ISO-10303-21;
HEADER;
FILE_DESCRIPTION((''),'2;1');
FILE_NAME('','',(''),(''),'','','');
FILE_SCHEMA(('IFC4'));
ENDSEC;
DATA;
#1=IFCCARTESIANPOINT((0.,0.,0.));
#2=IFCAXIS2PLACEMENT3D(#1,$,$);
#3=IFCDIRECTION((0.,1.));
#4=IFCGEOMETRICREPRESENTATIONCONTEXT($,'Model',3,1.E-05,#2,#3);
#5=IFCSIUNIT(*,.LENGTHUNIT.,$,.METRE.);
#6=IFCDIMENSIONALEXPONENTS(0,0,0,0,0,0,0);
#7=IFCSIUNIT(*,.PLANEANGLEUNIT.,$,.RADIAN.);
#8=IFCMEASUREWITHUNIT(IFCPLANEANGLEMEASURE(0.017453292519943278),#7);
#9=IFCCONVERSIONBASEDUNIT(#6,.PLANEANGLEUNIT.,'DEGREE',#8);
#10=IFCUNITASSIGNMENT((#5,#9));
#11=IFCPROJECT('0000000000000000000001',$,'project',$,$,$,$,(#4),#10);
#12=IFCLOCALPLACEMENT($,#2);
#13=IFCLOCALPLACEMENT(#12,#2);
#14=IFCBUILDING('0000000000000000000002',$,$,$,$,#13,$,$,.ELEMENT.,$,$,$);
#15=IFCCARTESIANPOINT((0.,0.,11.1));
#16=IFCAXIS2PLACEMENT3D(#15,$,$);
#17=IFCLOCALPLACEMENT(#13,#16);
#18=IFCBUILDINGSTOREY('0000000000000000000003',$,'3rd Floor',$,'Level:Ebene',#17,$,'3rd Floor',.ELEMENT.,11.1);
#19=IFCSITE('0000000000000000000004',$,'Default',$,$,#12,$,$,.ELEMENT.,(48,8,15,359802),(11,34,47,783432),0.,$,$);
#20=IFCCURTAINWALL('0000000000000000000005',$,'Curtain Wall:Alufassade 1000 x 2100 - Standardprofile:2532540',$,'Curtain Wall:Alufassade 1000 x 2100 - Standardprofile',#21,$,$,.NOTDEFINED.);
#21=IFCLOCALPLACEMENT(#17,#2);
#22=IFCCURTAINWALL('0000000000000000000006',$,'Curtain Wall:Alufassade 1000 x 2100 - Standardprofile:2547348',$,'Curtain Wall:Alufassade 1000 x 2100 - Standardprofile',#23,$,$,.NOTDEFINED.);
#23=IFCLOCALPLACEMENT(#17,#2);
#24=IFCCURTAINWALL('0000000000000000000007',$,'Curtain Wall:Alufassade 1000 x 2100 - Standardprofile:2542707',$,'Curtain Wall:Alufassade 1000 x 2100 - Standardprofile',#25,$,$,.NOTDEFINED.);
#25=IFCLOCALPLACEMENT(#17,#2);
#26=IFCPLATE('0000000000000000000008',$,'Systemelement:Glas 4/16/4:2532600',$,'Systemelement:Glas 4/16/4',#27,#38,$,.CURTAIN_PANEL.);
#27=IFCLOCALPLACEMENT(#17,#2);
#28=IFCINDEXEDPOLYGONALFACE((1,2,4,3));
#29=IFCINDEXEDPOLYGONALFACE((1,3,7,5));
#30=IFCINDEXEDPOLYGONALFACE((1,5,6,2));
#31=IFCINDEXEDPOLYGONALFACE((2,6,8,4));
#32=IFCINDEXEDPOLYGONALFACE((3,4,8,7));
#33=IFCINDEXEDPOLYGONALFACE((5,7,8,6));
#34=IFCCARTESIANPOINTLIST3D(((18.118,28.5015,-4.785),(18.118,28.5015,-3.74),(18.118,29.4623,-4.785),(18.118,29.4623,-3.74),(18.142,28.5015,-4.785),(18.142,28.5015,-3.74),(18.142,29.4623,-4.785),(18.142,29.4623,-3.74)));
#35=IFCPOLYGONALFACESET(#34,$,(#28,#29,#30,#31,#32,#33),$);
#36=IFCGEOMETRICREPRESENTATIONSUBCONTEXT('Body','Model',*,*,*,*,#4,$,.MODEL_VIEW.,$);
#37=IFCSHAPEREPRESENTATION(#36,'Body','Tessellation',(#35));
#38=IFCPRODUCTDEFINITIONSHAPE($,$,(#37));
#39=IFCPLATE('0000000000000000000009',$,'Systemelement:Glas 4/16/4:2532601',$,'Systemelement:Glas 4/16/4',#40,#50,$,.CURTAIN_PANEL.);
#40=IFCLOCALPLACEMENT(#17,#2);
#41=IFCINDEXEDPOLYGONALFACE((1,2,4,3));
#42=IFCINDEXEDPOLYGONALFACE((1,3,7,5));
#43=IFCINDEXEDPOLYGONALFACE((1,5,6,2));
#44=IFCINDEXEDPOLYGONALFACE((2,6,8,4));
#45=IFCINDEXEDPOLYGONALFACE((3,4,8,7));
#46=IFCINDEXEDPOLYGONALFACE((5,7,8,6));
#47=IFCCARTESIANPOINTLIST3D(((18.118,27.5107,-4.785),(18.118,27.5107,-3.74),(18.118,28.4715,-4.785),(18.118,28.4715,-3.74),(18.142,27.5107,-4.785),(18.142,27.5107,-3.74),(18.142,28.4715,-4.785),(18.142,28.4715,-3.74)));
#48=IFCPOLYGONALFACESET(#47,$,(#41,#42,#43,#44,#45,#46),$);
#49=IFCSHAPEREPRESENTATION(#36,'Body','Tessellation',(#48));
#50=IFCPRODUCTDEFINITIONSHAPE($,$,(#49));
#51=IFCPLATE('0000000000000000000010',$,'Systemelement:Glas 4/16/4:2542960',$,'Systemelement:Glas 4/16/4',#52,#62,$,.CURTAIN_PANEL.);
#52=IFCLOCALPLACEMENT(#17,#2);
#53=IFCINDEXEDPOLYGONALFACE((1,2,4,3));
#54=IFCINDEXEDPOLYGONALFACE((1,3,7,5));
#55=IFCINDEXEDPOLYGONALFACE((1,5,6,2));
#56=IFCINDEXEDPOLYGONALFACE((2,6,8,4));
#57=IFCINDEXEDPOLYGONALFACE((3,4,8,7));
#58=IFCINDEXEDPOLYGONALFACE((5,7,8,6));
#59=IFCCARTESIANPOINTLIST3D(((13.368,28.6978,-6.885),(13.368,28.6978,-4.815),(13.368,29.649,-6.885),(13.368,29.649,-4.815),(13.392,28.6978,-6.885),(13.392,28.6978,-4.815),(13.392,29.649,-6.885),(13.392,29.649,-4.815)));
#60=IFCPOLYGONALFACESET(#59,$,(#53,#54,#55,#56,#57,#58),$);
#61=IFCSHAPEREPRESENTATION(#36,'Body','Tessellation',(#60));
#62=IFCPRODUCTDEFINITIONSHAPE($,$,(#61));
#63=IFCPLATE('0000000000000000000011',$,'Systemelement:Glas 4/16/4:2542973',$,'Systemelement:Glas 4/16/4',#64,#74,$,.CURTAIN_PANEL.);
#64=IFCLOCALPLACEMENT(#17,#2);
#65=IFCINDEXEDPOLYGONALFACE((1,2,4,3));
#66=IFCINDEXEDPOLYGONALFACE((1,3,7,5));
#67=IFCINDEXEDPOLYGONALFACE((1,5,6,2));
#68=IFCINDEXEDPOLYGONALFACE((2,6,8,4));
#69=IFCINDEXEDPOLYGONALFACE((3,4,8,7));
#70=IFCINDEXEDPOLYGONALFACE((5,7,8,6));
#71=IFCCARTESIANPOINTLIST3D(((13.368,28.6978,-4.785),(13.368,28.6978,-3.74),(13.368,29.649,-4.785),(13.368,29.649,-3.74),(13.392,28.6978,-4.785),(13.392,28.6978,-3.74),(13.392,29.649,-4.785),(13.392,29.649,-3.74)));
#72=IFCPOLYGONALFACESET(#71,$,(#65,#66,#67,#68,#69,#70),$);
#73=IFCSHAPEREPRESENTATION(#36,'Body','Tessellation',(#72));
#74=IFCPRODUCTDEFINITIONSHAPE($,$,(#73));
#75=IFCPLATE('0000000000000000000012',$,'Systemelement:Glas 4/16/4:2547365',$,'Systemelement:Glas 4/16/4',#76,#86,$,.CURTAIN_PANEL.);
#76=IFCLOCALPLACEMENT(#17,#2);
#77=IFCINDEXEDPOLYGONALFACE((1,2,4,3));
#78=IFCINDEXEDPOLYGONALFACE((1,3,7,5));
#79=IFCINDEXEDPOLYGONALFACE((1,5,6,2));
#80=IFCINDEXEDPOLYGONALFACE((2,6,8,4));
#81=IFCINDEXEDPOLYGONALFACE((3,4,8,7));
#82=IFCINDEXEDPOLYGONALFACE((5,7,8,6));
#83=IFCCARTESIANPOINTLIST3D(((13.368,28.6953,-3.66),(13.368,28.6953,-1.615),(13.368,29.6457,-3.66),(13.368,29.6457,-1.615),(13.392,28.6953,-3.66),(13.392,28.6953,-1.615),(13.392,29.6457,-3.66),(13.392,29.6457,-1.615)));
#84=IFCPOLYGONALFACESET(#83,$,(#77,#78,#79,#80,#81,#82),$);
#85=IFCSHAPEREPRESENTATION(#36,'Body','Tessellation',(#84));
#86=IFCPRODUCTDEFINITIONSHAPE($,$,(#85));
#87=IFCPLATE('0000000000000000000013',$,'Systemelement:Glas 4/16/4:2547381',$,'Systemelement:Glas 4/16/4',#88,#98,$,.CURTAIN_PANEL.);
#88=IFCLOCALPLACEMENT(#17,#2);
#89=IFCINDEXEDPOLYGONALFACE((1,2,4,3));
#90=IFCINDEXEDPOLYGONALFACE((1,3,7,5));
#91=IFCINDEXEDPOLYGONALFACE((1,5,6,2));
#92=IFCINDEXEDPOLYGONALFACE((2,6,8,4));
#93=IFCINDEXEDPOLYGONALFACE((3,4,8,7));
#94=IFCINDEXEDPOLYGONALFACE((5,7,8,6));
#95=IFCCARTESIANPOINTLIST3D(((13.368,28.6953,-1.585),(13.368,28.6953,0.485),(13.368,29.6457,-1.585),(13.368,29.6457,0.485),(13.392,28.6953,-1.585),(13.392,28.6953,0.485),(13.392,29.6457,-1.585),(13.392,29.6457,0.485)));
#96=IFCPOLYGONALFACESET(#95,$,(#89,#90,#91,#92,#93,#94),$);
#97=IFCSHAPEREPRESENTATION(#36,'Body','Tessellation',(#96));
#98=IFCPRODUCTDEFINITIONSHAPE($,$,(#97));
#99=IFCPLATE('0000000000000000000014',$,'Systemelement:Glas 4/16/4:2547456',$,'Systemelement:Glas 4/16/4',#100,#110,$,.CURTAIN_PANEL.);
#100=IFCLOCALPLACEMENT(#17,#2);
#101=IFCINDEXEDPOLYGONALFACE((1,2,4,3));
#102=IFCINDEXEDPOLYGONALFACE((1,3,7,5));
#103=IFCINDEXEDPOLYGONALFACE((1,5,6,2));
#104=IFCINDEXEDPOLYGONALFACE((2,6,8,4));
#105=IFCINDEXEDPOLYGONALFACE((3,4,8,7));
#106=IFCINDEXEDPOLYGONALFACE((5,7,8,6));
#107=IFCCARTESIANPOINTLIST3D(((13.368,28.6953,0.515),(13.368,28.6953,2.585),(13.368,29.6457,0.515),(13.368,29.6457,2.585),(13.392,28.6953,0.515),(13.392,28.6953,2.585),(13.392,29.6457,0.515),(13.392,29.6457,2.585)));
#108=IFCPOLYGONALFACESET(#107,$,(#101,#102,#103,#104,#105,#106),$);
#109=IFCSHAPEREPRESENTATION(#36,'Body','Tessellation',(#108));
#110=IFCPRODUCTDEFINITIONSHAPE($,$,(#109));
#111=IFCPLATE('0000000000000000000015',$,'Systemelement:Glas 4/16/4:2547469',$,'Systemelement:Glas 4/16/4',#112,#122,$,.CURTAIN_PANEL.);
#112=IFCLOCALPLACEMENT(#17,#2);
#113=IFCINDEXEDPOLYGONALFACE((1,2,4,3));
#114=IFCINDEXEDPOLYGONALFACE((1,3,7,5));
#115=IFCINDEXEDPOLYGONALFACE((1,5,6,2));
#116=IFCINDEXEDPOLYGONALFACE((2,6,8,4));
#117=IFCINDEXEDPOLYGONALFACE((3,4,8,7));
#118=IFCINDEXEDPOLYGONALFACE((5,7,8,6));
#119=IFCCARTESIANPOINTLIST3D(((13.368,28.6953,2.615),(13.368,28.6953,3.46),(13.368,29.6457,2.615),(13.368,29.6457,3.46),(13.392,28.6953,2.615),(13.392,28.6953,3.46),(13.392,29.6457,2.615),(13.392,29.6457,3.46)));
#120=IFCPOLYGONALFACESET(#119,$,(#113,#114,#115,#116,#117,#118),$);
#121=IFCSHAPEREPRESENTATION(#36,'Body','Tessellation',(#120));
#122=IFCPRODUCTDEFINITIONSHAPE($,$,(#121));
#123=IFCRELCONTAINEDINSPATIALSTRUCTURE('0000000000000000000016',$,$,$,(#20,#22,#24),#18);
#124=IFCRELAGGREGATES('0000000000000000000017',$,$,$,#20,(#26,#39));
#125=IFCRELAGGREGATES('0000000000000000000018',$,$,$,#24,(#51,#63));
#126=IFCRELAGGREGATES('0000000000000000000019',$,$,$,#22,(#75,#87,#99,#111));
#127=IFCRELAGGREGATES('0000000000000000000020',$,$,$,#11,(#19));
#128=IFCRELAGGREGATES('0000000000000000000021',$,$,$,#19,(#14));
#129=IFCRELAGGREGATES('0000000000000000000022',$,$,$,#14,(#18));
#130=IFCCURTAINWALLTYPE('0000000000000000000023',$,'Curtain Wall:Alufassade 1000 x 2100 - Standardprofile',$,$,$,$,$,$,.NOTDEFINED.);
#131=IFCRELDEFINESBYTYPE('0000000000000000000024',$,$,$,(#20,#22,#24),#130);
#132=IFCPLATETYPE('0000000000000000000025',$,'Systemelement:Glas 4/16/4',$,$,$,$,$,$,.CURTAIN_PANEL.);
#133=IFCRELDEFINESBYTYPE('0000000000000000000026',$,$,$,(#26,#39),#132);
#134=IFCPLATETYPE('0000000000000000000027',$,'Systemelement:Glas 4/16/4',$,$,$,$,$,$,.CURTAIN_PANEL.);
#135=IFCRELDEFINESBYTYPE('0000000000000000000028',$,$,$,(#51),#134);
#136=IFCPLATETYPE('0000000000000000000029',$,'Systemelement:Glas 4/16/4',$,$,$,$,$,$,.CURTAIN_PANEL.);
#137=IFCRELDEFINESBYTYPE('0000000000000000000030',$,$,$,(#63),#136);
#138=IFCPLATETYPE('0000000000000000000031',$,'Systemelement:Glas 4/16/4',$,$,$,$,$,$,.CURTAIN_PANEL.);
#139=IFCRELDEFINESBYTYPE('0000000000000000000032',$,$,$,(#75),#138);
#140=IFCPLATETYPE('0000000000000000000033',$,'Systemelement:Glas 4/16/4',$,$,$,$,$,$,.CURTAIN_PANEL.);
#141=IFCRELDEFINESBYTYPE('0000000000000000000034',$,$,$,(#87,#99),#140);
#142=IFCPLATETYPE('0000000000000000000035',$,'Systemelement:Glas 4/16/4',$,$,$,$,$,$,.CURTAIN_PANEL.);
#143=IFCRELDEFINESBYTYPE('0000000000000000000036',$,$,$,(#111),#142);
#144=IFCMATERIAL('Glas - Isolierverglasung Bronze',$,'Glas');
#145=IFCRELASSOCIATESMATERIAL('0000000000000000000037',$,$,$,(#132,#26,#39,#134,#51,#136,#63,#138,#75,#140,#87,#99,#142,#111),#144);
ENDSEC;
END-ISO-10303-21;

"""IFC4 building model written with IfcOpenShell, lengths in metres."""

from ifc_helpers import new_model, entity, si_unit, converted_unit, direction, frame, origin, place, context, subcontext, project, spatial, indexed_curve, outline, extrude, source, transform, mapped, material, type_object, type_shapes, element, aggregate, save


model = new_model("IFC4")

# Units and contexts
model_context = context("Model", 3, precision=1e-05, world=origin(), true_north=direction((0.0, 1.0)))
body_context = subcontext(model_context, "Body", "Model", "MODEL_VIEW")
ifc_project = project(units=[si_unit("LENGTHUNIT", "METRE"), converted_unit("PLANEANGLEUNIT", "DEGREE", entity("IfcPlaneAngleMeasure", 0.017453292519943278), si_unit("PLANEANGLEUNIT", "RADIAN"), dimensions=[0, 0, 0, 0, 0, 0, 0])], contexts=[model_context])

# Site, building, storey
site_placement = place(None, origin())
site = spatial("IfcSite", under=ifc_project, at=site_placement, Name="Default", CompositionType="ELEMENT", RefLatitude=(48, 8, 15, 359802), RefLongitude=(11, 34, 47, 783432), RefElevation=0.0)
building_placement = place(site_placement, origin())
building = spatial("IfcBuilding", under=site, at=building_placement, CompositionType="ELEMENT")
storey_placement = place(building_placement, frame((0.0, 0.0, 11.1)))
storey = spatial("IfcBuildingStorey", under=building, at=storey_placement, Name="3rd Floor", ObjectType="Level:Ebene", LongName="3rd Floor", CompositionType="ELEMENT", Elevation=11.1)

# Curtain walls
curtain_wall_type = type_object("IfcCurtainWallType", Name="Curtain Wall:Alufassade 1000 x 2100 - Standardprofile", PredefinedType="NOTDEFINED")
curtain_wall_1_placement = place(storey_placement, frame((0.0, 0.0, -11.1)))
curtain_wall_1 = element("IfcCurtainWall", 1, at=curtain_wall_1_placement, inside=storey, type_object=curtain_wall_type, Name="Curtain Wall:Alufassade 1000 x 2100 - Standardprofile:2532540", ObjectType="Curtain Wall:Alufassade 1000 x 2100 - Standardprofile", PredefinedType="NOTDEFINED")
curtain_wall_2_placement = place(storey_placement, frame((0.0, 0.0, -11.1)))
curtain_wall_2 = element("IfcCurtainWall", 2, at=curtain_wall_2_placement, inside=storey, type_object=curtain_wall_type, Name="Curtain Wall:Alufassade 1000 x 2100 - Standardprofile:2547348", ObjectType="Curtain Wall:Alufassade 1000 x 2100 - Standardprofile", PredefinedType="NOTDEFINED")

# Curtain wall
curtain_wall_3_placement = place(storey_placement, frame((0.0, 0.0, -11.1)))
curtain_wall_3 = element("IfcCurtainWall", 3, at=curtain_wall_3_placement, inside=storey, type_object=curtain_wall_type, Name="Curtain Wall:Alufassade 1000 x 2100 - Standardprofile:2542707", ObjectType="Curtain Wall:Alufassade 1000 x 2100 - Standardprofile", PredefinedType="NOTDEFINED")

# Plates
ifc_material_1 = material(Name="Glas - Isolierverglasung Bronze", Category="Glas")
plate_type_1 = type_object("IfcPlateType", Name="Systemelement:Glas 4/16/4", PredefinedType="CURTAIN_PANEL", material=ifc_material_1)
shared_shape_1 = source(origin(), body_context, "Body", "SweptSolid", [
    extrude(outline(indexed_curve([(-0.012, -0.4804), (0.012, -0.4804), (0.012, 0.4804), (-0.012, 0.4804), (-0.012, -0.4804)], self_intersect=False)), frame((0.0, 0.0, 0.0), z_axis=(0.0, 0.0, 1.0), x_axis=(0.0, 1.0, 0.0)), (0.0, 0.0, 1.0), 1.045),
])
type_shapes(plate_type_1, [shared_shape_1])
plate_1_placement = place(curtain_wall_1_placement, frame((18.13, 28.9819, 6.315), z_axis=(0.0, 0.0, 1.0), x_axis=(0.0, -1.0, 0.0)))
plate_1 = element("IfcPlate", 4, at=plate_1_placement, type_object=plate_type_1, material=ifc_material_1, Name="Systemelement:Glas 4/16/4:2532600", ObjectType="Systemelement:Glas 4/16/4", PredefinedType="CURTAIN_PANEL", context=body_context, shape_type="MappedRepresentation", body=[
    mapped(shared_shape_1, transform((0.0, 0.0, 0.0), scale=1.0)),
])
plate_2_placement = place(curtain_wall_1_placement, frame((18.13, 27.9911, 6.315), z_axis=(0.0, 0.0, 1.0), x_axis=(0.0, -1.0, 0.0)))
plate_2 = element("IfcPlate", 5, at=plate_2_placement, type_object=plate_type_1, material=ifc_material_1, Name="Systemelement:Glas 4/16/4:2532601", ObjectType="Systemelement:Glas 4/16/4", PredefinedType="CURTAIN_PANEL", context=body_context, shape_type="MappedRepresentation", body=[
    mapped(shared_shape_1, transform((0.0, 0.0, 0.0), scale=1.0)),
])
aggregate(curtain_wall_1, [plate_1, plate_2])
plate_type_2 = type_object("IfcPlateType", Name="Systemelement:Glas 4/16/4", PredefinedType="CURTAIN_PANEL", material=ifc_material_1)
shared_shape_2 = source(origin(), body_context, "Body", "SweptSolid", [
    extrude(outline(indexed_curve([(-0.012, -0.4756), (0.012, -0.4756), (0.012, 0.4756), (-0.012, 0.4756), (-0.012, -0.4756)], self_intersect=False)), frame((0.0, 0.0, 0.0), z_axis=(0.0, 0.0, 1.0), x_axis=(0.0, 1.0, 0.0)), (0.0, 0.0, 1.0), 2.07),
])
type_shapes(plate_type_2, [shared_shape_2])
plate_3_placement = place(curtain_wall_3_placement, frame((13.38, 29.1734, 4.215), z_axis=(0.0, 0.0, 1.0), x_axis=(0.0, -1.0, 0.0)))
plate_3 = element("IfcPlate", 6, at=plate_3_placement, type_object=plate_type_2, material=ifc_material_1, Name="Systemelement:Glas 4/16/4:2542960", ObjectType="Systemelement:Glas 4/16/4", PredefinedType="CURTAIN_PANEL", context=body_context, shape_type="MappedRepresentation", body=[
    mapped(shared_shape_2, transform((0.0, 0.0, 0.0), scale=1.0)),
])
plate_type_3 = type_object("IfcPlateType", Name="Systemelement:Glas 4/16/4", PredefinedType="CURTAIN_PANEL", material=ifc_material_1)
shared_shape_3 = source(origin(), body_context, "Body", "SweptSolid", [
    extrude(outline(indexed_curve([(-0.012, -0.4756), (0.012, -0.4756), (0.012, 0.4756), (-0.012, 0.4756), (-0.012, -0.4756)], self_intersect=False)), frame((0.0, 0.0, 0.0), z_axis=(0.0, 0.0, 1.0), x_axis=(0.0, 1.0, 0.0)), (0.0, 0.0, 1.0), 1.045),
])
type_shapes(plate_type_3, [shared_shape_3])
plate_4_placement = place(curtain_wall_3_placement, frame((13.38, 29.1734, 6.315), z_axis=(0.0, 0.0, 1.0), x_axis=(0.0, -1.0, 0.0)))
plate_4 = element("IfcPlate", 7, at=plate_4_placement, type_object=plate_type_3, material=ifc_material_1, Name="Systemelement:Glas 4/16/4:2542973", ObjectType="Systemelement:Glas 4/16/4", PredefinedType="CURTAIN_PANEL", context=body_context, shape_type="MappedRepresentation", body=[
    mapped(shared_shape_3, transform((0.0, 0.0, 0.0), scale=1.0)),
])
aggregate(curtain_wall_3, [plate_3, plate_4])
plate_type_4 = type_object("IfcPlateType", Name="Systemelement:Glas 4/16/4", PredefinedType="CURTAIN_PANEL", material=ifc_material_1)
shared_shape_4 = source(origin(), body_context, "Body", "SweptSolid", [
    extrude(outline(indexed_curve([(-0.012, -0.4752), (0.012, -0.4752), (0.012, 0.4752), (-0.012, 0.4752), (-0.012, -0.4752)], self_intersect=False)), frame((0.0, 0.0, 0.0), z_axis=(0.0, 0.0, 1.0), x_axis=(0.0, 1.0, 0.0)), (0.0, 0.0, 1.0), 2.045),
])
type_shapes(plate_type_4, [shared_shape_4])
plate_5_placement = place(curtain_wall_2_placement, frame((13.38, 29.1705, 7.44), z_axis=(0.0, 0.0, 1.0), x_axis=(0.0, -1.0, 0.0)))
plate_5 = element("IfcPlate", 8, at=plate_5_placement, type_object=plate_type_4, material=ifc_material_1, Name="Systemelement:Glas 4/16/4:2547365", ObjectType="Systemelement:Glas 4/16/4", PredefinedType="CURTAIN_PANEL", context=body_context, shape_type="MappedRepresentation", body=[
    mapped(shared_shape_4, transform((0.0, 0.0, 0.0), scale=1.0)),
])
plate_type_5 = type_object("IfcPlateType", Name="Systemelement:Glas 4/16/4", PredefinedType="CURTAIN_PANEL", material=ifc_material_1)
shared_shape_5 = source(origin(), body_context, "Body", "SweptSolid", [
    extrude(outline(indexed_curve([(-0.012, -0.4752), (0.012, -0.4752), (0.012, 0.4752), (-0.012, 0.4752), (-0.012, -0.4752)], self_intersect=False)), frame((0.0, 0.0, 0.0), z_axis=(0.0, 0.0, 1.0), x_axis=(0.0, 1.0, 0.0)), (0.0, 0.0, 1.0), 2.07),
])
type_shapes(plate_type_5, [shared_shape_5])
plate_6_placement = place(curtain_wall_2_placement, frame((13.38, 29.1705, 9.515), z_axis=(0.0, 0.0, 1.0), x_axis=(0.0, -1.0, 0.0)))
plate_6 = element("IfcPlate", 9, at=plate_6_placement, type_object=plate_type_5, material=ifc_material_1, Name="Systemelement:Glas 4/16/4:2547381", ObjectType="Systemelement:Glas 4/16/4", PredefinedType="CURTAIN_PANEL", context=body_context, shape_type="MappedRepresentation", body=[
    mapped(shared_shape_5, transform((0.0, 0.0, 0.0), scale=1.0)),
])
plate_7_placement = place(curtain_wall_2_placement, frame((13.38, 29.1705, 11.615), z_axis=(0.0, 0.0, 1.0), x_axis=(0.0, -1.0, 0.0)))
plate_7 = element("IfcPlate", 10, at=plate_7_placement, type_object=plate_type_5, material=ifc_material_1, Name="Systemelement:Glas 4/16/4:2547456", ObjectType="Systemelement:Glas 4/16/4", PredefinedType="CURTAIN_PANEL", context=body_context, shape_type="MappedRepresentation", body=[
    mapped(shared_shape_5, transform((0.0, 0.0, 0.0), scale=1.0)),
])
plate_type_6 = type_object("IfcPlateType", Name="Systemelement:Glas 4/16/4", PredefinedType="CURTAIN_PANEL", material=ifc_material_1)
shared_shape_6 = source(origin(), body_context, "Body", "SweptSolid", [
    extrude(outline(indexed_curve([(-0.012, -0.4752), (0.012, -0.4752), (0.012, 0.4752), (-0.012, 0.4752), (-0.012, -0.4752)], self_intersect=False)), frame((0.0, 0.0, 0.0), z_axis=(0.0, 0.0, 1.0), x_axis=(0.0, 1.0, 0.0)), (0.0, 0.0, 1.0), 0.845),
])
type_shapes(plate_type_6, [shared_shape_6])
plate_8_placement = place(curtain_wall_2_placement, frame((13.38, 29.1705, 13.715), z_axis=(0.0, 0.0, 1.0), x_axis=(0.0, -1.0, 0.0)))
plate_8 = element("IfcPlate", 11, at=plate_8_placement, type_object=plate_type_6, material=ifc_material_1, Name="Systemelement:Glas 4/16/4:2547469", ObjectType="Systemelement:Glas 4/16/4", PredefinedType="CURTAIN_PANEL", context=body_context, shape_type="MappedRepresentation", body=[
    mapped(shared_shape_6, transform((0.0, 0.0, 0.0), scale=1.0)),
])
aggregate(curtain_wall_2, [plate_5, plate_6, plate_7, plate_8])

save(model, "model.ifc")
